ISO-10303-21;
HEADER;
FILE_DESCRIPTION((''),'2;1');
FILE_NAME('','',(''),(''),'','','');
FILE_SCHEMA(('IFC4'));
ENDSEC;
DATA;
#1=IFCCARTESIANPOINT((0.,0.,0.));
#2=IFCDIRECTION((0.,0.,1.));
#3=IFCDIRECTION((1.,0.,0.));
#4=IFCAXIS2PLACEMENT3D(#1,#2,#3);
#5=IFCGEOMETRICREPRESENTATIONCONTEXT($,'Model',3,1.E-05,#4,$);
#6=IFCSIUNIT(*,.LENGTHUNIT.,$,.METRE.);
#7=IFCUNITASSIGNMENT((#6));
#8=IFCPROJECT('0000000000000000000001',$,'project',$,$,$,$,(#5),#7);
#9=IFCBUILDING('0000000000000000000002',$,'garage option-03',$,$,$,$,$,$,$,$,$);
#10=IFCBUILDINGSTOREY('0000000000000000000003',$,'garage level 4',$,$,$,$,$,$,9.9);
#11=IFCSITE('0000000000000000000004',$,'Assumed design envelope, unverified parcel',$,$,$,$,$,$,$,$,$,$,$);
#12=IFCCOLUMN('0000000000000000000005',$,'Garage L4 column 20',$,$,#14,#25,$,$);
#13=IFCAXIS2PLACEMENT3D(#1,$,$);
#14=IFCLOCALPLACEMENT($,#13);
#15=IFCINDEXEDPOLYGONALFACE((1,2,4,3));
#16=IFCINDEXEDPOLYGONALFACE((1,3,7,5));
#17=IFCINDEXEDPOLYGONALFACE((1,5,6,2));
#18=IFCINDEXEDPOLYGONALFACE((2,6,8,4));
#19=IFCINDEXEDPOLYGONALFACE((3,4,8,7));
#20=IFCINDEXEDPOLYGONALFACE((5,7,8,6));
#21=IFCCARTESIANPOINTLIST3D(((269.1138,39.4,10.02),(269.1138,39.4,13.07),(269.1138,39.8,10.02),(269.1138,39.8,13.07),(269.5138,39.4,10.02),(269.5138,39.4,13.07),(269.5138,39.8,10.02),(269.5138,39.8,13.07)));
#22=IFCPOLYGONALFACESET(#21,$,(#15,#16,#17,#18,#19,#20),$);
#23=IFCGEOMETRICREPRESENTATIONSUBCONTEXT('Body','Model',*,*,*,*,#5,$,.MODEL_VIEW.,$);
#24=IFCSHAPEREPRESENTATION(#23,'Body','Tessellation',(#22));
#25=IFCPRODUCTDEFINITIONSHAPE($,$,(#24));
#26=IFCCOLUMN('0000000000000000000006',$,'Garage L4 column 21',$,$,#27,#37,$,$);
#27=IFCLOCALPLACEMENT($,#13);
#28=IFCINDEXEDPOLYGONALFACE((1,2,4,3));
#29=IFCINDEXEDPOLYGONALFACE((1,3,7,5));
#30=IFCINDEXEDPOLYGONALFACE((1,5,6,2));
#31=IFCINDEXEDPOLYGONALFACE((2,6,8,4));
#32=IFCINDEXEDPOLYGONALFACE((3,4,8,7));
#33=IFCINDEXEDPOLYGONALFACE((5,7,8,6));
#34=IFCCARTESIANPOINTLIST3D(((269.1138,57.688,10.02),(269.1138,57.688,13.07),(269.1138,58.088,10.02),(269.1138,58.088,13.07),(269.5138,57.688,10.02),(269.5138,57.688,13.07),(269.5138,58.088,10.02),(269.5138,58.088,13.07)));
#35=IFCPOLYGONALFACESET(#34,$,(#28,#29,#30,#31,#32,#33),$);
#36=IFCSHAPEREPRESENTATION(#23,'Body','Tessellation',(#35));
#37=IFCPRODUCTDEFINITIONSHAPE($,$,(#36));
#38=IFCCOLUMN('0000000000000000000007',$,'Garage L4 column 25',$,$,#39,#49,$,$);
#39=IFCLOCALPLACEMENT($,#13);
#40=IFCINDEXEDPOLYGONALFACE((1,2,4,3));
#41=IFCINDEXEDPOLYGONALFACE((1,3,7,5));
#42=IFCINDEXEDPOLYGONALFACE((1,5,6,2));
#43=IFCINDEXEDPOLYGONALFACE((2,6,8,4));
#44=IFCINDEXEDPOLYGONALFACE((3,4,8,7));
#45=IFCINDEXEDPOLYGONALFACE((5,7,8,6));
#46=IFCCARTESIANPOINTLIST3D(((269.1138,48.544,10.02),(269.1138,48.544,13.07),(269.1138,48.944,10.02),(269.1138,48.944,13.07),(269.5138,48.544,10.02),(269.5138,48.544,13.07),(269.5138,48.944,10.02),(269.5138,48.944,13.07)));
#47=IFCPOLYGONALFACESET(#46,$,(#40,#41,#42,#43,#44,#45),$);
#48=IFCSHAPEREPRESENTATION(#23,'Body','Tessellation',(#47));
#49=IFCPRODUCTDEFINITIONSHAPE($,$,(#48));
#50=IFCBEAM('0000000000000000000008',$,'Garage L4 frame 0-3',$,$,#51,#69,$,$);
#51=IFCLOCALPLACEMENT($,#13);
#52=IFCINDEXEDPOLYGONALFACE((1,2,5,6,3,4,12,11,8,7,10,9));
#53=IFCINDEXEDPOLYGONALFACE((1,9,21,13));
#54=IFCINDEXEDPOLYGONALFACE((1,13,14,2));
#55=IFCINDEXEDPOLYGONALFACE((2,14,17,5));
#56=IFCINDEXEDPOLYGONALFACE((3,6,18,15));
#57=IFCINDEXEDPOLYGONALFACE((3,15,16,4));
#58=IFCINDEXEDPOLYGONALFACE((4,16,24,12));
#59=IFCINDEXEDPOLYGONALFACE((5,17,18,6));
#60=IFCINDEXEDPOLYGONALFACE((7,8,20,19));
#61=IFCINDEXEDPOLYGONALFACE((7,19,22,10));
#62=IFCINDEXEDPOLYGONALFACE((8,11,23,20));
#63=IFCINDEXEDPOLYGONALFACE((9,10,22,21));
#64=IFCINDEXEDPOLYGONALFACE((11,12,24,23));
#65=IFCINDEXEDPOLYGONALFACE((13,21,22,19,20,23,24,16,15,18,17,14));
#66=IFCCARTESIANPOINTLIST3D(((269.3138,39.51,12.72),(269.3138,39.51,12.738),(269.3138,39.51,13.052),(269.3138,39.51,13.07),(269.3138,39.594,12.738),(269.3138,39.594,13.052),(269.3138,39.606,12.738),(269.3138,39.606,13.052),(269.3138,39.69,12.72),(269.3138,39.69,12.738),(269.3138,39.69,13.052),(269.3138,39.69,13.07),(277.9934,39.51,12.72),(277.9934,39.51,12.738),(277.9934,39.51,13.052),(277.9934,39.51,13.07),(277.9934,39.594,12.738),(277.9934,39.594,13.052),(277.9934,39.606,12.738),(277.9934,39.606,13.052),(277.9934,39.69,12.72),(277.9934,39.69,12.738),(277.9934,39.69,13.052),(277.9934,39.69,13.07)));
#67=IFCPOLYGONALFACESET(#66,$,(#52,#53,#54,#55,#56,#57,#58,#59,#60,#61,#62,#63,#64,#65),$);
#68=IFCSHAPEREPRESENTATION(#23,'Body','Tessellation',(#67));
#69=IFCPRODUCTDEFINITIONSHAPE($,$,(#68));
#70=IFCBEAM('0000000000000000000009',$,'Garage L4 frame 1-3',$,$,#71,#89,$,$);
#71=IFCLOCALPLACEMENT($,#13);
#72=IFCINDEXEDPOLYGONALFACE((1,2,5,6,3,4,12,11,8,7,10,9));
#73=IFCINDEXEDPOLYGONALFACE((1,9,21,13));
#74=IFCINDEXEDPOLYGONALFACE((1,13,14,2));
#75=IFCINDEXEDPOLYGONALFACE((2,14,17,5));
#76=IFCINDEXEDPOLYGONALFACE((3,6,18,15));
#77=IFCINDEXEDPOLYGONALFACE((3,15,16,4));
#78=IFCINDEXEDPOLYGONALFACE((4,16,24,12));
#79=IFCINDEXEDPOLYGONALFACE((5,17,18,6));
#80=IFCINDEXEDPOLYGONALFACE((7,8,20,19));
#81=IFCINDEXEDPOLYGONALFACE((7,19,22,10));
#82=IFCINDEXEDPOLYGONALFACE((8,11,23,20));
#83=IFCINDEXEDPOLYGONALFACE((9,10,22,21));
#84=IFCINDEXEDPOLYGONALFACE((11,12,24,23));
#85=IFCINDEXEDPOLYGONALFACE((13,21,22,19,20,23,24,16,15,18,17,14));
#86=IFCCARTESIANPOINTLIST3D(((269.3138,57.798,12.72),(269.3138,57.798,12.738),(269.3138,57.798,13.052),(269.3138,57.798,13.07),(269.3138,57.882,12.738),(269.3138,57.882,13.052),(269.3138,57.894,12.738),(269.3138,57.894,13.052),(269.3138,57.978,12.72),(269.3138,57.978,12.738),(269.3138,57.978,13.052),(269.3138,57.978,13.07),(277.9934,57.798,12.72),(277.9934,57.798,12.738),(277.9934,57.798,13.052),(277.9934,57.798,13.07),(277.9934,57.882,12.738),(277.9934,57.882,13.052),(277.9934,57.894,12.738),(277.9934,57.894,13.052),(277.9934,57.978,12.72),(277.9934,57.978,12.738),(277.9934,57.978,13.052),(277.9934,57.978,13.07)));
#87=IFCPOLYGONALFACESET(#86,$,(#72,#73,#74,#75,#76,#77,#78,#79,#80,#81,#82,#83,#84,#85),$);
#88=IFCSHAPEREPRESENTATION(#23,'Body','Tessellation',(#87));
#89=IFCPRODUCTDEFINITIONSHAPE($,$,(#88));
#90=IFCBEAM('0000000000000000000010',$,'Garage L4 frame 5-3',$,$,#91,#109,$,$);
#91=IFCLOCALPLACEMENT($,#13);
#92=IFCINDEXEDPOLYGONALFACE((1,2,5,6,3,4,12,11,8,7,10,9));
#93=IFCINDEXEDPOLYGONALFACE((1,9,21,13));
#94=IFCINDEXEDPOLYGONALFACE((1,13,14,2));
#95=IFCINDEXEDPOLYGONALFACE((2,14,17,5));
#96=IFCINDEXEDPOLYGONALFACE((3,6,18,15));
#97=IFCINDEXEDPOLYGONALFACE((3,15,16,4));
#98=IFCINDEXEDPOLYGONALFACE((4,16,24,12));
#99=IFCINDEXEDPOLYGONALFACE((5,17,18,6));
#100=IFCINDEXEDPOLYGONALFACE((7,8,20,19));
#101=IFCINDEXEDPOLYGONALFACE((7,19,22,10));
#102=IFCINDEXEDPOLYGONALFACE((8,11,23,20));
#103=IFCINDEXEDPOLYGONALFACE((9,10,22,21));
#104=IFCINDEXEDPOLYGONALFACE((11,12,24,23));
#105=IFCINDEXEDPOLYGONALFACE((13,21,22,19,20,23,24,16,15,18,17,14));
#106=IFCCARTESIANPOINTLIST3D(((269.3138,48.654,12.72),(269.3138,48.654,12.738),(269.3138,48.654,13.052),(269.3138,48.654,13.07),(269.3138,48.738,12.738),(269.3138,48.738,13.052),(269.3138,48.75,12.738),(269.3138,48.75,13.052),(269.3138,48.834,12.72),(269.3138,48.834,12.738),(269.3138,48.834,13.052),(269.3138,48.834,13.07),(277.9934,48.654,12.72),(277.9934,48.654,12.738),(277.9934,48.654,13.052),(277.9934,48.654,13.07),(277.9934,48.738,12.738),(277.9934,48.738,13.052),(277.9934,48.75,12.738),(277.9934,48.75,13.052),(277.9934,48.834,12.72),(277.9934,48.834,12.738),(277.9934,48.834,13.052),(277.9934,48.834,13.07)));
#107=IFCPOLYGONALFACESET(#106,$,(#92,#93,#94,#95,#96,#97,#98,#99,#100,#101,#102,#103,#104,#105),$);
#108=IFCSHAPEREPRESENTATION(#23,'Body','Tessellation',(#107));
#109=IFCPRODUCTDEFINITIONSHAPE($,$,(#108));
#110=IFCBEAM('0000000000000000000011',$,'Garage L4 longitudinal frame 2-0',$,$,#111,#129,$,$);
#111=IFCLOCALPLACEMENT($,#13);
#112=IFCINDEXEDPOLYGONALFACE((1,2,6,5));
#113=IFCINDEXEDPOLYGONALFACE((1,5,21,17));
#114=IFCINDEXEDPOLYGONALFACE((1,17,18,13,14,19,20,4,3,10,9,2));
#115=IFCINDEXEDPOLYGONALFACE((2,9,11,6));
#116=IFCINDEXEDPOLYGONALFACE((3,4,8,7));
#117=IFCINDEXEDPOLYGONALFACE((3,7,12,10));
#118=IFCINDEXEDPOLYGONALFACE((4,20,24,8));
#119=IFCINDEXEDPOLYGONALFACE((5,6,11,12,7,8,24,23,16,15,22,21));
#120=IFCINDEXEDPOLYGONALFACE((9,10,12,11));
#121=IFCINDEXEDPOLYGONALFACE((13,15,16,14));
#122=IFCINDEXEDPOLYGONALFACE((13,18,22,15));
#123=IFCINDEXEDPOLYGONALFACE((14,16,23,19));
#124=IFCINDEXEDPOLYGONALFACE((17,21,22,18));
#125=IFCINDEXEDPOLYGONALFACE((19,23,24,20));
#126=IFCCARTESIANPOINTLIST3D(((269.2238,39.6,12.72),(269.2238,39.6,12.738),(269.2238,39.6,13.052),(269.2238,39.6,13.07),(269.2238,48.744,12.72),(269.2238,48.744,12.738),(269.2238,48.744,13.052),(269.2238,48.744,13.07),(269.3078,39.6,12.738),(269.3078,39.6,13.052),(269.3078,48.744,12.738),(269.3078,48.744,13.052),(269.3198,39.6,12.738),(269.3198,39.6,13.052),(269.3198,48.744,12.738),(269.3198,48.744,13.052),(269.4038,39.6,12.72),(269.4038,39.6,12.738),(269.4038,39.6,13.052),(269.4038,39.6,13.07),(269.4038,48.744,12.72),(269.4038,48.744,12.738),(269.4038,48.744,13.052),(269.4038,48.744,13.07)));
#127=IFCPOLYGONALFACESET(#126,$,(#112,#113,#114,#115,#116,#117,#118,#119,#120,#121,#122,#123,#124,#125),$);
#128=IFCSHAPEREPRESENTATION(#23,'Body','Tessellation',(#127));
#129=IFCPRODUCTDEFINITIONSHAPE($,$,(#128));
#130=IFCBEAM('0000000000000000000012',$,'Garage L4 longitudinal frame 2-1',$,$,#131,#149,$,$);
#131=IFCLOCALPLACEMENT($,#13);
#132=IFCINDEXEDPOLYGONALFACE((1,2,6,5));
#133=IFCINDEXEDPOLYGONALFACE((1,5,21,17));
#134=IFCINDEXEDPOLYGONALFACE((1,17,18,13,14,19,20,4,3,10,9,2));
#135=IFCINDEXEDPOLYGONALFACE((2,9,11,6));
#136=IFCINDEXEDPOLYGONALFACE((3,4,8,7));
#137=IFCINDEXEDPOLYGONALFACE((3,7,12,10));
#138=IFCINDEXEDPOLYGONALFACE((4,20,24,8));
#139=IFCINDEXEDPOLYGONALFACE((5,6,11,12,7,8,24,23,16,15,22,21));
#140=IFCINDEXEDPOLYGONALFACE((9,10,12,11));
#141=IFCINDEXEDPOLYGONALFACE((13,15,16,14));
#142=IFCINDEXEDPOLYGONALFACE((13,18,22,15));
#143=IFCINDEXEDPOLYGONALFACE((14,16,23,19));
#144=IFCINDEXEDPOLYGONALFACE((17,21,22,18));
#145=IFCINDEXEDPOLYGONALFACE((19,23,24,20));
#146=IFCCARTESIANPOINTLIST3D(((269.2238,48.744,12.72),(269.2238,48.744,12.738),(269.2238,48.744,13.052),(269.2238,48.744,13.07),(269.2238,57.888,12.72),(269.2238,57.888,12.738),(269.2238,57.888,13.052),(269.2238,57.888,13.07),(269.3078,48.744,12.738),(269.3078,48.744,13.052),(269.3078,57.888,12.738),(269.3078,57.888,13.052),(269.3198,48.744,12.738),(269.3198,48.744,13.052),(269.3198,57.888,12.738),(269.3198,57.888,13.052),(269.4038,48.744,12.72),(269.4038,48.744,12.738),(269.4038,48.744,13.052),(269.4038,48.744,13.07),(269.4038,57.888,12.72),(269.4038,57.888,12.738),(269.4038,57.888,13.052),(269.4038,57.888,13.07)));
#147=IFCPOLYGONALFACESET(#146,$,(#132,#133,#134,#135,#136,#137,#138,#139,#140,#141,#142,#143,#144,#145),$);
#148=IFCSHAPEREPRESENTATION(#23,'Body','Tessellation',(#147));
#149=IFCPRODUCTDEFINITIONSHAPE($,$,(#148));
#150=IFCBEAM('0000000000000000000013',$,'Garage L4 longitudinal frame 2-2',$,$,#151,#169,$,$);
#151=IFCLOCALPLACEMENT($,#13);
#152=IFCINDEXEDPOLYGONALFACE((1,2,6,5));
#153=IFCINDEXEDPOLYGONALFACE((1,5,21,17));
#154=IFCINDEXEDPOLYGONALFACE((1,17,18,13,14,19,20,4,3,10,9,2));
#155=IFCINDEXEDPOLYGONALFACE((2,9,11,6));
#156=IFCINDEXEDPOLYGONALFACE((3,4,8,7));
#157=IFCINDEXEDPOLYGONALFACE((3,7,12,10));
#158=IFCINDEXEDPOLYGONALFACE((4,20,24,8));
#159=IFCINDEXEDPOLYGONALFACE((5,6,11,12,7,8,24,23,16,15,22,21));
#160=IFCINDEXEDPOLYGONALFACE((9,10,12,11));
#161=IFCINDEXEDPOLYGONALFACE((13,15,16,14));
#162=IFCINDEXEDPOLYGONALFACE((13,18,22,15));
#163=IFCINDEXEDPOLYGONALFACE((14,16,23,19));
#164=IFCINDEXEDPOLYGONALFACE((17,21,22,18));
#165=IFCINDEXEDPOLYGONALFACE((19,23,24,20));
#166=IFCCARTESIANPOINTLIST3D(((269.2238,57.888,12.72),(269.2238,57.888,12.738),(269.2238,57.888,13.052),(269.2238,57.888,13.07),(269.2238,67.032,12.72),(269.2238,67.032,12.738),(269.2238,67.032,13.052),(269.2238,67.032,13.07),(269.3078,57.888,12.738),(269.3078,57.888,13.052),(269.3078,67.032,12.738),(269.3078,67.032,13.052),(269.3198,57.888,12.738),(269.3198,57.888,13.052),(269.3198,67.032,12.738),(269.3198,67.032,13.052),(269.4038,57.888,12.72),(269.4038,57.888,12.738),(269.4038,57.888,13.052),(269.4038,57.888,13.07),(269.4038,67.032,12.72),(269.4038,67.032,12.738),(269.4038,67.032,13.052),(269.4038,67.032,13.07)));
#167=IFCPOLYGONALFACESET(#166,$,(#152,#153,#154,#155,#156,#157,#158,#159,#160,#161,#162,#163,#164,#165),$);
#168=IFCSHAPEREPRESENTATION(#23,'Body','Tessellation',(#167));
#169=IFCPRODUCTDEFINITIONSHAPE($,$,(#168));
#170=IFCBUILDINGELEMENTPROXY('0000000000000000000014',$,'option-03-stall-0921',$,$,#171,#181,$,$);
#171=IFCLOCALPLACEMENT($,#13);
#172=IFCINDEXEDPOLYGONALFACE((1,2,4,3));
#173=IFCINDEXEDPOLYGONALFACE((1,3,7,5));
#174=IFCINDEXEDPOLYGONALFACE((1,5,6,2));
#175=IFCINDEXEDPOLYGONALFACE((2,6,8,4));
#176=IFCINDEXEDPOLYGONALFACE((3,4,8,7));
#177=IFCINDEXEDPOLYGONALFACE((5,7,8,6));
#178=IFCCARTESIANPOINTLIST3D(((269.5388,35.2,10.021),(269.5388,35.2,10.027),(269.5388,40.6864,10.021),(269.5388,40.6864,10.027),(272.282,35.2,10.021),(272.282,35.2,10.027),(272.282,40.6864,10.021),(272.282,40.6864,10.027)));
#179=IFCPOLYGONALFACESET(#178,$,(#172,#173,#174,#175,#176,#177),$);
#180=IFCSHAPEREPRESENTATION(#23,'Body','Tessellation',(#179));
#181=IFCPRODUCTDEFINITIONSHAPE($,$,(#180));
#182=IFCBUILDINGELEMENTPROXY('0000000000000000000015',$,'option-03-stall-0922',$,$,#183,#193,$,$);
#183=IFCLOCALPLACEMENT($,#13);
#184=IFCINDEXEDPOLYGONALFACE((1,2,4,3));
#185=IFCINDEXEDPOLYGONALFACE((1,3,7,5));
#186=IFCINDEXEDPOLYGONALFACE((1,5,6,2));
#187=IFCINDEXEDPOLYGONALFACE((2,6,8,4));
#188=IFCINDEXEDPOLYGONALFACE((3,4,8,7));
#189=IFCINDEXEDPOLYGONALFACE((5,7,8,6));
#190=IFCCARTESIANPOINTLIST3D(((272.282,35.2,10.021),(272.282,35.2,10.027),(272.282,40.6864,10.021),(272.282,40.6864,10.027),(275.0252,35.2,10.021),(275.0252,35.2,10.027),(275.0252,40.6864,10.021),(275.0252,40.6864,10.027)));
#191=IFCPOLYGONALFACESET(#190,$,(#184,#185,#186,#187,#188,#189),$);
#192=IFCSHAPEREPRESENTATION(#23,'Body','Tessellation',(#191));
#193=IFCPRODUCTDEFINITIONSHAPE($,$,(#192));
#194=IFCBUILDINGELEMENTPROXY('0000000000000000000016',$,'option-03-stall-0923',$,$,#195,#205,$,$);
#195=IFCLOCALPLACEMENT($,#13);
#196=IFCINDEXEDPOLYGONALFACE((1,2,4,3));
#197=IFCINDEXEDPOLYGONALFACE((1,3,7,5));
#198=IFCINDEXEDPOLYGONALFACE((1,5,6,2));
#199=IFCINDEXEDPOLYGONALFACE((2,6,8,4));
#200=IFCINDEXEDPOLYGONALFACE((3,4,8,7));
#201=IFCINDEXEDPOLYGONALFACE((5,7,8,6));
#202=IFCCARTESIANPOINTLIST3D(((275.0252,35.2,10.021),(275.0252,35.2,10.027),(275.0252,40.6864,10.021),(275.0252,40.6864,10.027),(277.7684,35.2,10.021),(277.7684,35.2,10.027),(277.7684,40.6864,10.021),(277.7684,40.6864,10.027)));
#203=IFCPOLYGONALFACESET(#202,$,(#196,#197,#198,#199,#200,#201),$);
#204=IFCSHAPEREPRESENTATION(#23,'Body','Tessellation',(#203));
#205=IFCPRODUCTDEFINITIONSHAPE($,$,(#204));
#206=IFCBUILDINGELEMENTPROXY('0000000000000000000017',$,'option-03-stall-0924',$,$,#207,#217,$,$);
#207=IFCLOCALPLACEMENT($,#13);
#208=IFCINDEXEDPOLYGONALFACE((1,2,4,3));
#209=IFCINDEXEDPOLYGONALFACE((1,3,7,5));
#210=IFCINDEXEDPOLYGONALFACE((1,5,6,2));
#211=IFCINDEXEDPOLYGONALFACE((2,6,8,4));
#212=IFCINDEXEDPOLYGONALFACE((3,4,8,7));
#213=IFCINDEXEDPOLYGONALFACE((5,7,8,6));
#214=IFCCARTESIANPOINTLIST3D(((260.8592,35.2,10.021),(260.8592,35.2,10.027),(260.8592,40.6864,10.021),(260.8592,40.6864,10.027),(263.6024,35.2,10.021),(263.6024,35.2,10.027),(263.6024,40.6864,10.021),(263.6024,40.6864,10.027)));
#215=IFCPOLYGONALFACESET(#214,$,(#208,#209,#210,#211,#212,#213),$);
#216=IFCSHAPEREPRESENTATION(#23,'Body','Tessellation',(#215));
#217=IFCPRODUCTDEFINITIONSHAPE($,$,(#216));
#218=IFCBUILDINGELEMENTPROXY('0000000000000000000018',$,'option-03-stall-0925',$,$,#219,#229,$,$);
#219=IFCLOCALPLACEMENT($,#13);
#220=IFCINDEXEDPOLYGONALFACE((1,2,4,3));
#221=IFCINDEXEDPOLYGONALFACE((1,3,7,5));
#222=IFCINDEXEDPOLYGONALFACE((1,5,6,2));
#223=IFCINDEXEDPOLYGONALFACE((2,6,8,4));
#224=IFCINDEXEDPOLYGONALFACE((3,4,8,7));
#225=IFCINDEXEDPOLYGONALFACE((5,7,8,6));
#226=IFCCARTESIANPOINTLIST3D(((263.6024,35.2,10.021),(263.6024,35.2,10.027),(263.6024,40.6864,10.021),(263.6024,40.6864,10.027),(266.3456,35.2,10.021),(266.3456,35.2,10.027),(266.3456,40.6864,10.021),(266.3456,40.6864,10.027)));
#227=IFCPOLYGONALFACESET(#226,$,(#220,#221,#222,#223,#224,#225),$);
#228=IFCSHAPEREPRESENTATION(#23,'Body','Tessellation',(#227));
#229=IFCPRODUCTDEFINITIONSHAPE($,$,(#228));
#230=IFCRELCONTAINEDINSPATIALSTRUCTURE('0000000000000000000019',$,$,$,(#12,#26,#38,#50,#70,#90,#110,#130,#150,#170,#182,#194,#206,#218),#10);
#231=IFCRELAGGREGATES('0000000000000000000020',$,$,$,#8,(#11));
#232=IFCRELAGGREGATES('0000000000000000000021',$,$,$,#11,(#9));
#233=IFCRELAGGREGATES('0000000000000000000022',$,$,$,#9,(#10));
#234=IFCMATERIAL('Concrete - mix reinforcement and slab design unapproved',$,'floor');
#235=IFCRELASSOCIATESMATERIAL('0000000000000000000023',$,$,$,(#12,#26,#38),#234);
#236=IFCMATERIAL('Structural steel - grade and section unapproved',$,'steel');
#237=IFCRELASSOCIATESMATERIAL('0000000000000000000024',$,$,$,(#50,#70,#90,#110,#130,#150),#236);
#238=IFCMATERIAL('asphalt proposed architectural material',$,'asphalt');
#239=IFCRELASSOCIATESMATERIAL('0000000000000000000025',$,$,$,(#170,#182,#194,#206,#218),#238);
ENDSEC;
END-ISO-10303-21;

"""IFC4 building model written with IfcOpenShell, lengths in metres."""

from ifc_helpers import new_model, si_unit, frame, origin_with_axes, place, context, subcontext, project, spatial, rectangle, i_section, extrude, material, element, save


model = new_model("IFC4")

# Units and contexts
model_context = context("Model", 3, precision=1e-05, world=origin_with_axes())
body_context = subcontext(model_context, "Body", "Model", "MODEL_VIEW")
ifc_project = project(units=[si_unit("LENGTHUNIT", "METRE")], contexts=[model_context])

# Site, building, storey
site = spatial("IfcSite", under=ifc_project, Name="Assumed design envelope, unverified parcel")
building = spatial("IfcBuilding", under=site, Name="garage option-03")
storey = spatial("IfcBuildingStorey", under=building, Name="garage level 4", Elevation=9.9)

# Columns
ifc_material_1 = material(Name="Concrete - mix reinforcement and slab design unapproved", Category="floor")
for number, where, z_axis, x_axis, name in (
    (1, (269.3138, 39.6, 10.02), (0.0, 0.0, 1.0), (1.0, 0.0, 0.0), "Garage L4 column 20"),
    (2, (269.3138, 57.888, 10.02), (0.0, 0.0, 1.0), (1.0, 0.0, 0.0), "Garage L4 column 21"),
    (3, (269.3138, 48.744, 10.02), (0.0, 0.0, 1.0), (1.0, 0.0, 0.0), "Garage L4 column 25"),
):
    element("IfcColumn", number, at=place(None, frame(where, z_axis=z_axis, x_axis=x_axis)), inside=storey, material=ifc_material_1, Name=name, context=body_context, shape_type="SweptSolid", body=[
        extrude(rectangle(XDim=0.4, YDim=0.4), origin_with_axes(), (0.0, 0.0, 1.0), 3.05),
    ])

# Beams
ifc_material_2 = material(Name="Structural steel - grade and section unapproved", Category="steel")
for number, where, z_axis, x_axis, name in (
    (4, (269.3138, 39.6, 12.895), (1.0, 0.0, 0.0), (0.0, 1.0, 0.0), "Garage L4 frame 0-3"),
    (5, (269.3138, 57.888, 12.895), (1.0, 0.0, 0.0), (0.0, 1.0, 0.0), "Garage L4 frame 1-3"),
    (6, (269.3138, 48.744, 12.895), (1.0, 0.0, 0.0), (0.0, 1.0, 0.0), "Garage L4 frame 5-3"),
):
    element("IfcBeam", number, at=place(None, frame(where, z_axis=z_axis, x_axis=x_axis)), inside=storey, material=ifc_material_2, Name=name, context=body_context, shape_type="SweptSolid", body=[
        extrude(i_section(OverallWidth=0.18, OverallDepth=0.35, WebThickness=0.012, FlangeThickness=0.018, FilletRadius=0.0), origin_with_axes(), (0.0, 0.0, 1.0), 8.6796),
    ])
for number, where, z_axis, x_axis, name in (
    (7, (269.3138, 39.6, 12.895), (0.0, 1.0, 0.0), (-1.0, 0.0, 0.0), "Garage L4 longitudinal frame 2-0"),
    (8, (269.3138, 48.744, 12.895), (0.0, 1.0, 0.0), (-1.0, 0.0, 0.0), "Garage L4 longitudinal frame 2-1"),
):
    element("IfcBeam", number, at=place(None, frame(where, z_axis=z_axis, x_axis=x_axis)), inside=storey, material=ifc_material_2, Name=name, context=body_context, shape_type="SweptSolid", body=[
        extrude(i_section(OverallWidth=0.18, OverallDepth=0.35, WebThickness=0.012, FlangeThickness=0.018, FilletRadius=0.0), origin_with_axes(), (0.0, 0.0, 1.0), 9.144),
    ])
beam_placement = place(None, frame((269.3138, 57.888, 12.895), z_axis=(0.0, 1.0, 0.0), x_axis=(-1.0, 0.0, 0.0)))
element("IfcBeam", 9, at=beam_placement, inside=storey, material=ifc_material_2, Name="Garage L4 longitudinal frame 2-2", context=body_context, shape_type="SweptSolid", body=[
    extrude(i_section(OverallWidth=0.18, OverallDepth=0.35, WebThickness=0.012, FlangeThickness=0.018, FilletRadius=0.0), origin_with_axes(), (0.0, 0.0, 1.0), 9.144),
])

# Building element proxies
ifc_material_3 = material(Name="asphalt proposed architectural material", Category="asphalt")
for number, where, z_axis, x_axis, name in (
    (10, (270.9104, 37.9432, 10.021), (0.0, 0.0, 1.0), (1.0, 0.0, 0.0), "option-03-stall-0921"),
    (11, (273.6536, 37.9432, 10.021), (0.0, 0.0, 1.0), (1.0, 0.0, 0.0), "option-03-stall-0922"),
    (12, (276.3968, 37.9432, 10.021), (0.0, 0.0, 1.0), (1.0, 0.0, 0.0), "option-03-stall-0923"),
    (13, (262.2308, 37.9432, 10.021), (0.0, 0.0, 1.0), (1.0, 0.0, 0.0), "option-03-stall-0924"),
    (14, (264.974, 37.9432, 10.021), (0.0, 0.0, 1.0), (1.0, 0.0, 0.0), "option-03-stall-0925"),
):
    element("IfcBuildingElementProxy", number, at=place(None, frame(where, z_axis=z_axis, x_axis=x_axis)), inside=storey, material=ifc_material_3, Name=name, context=body_context, shape_type="SweptSolid", body=[
        extrude(rectangle(XDim=2.7432, YDim=5.4864), origin_with_axes(), (0.0, 0.0, 1.0), 0.006),
    ])

save(model, "model.ifc")
